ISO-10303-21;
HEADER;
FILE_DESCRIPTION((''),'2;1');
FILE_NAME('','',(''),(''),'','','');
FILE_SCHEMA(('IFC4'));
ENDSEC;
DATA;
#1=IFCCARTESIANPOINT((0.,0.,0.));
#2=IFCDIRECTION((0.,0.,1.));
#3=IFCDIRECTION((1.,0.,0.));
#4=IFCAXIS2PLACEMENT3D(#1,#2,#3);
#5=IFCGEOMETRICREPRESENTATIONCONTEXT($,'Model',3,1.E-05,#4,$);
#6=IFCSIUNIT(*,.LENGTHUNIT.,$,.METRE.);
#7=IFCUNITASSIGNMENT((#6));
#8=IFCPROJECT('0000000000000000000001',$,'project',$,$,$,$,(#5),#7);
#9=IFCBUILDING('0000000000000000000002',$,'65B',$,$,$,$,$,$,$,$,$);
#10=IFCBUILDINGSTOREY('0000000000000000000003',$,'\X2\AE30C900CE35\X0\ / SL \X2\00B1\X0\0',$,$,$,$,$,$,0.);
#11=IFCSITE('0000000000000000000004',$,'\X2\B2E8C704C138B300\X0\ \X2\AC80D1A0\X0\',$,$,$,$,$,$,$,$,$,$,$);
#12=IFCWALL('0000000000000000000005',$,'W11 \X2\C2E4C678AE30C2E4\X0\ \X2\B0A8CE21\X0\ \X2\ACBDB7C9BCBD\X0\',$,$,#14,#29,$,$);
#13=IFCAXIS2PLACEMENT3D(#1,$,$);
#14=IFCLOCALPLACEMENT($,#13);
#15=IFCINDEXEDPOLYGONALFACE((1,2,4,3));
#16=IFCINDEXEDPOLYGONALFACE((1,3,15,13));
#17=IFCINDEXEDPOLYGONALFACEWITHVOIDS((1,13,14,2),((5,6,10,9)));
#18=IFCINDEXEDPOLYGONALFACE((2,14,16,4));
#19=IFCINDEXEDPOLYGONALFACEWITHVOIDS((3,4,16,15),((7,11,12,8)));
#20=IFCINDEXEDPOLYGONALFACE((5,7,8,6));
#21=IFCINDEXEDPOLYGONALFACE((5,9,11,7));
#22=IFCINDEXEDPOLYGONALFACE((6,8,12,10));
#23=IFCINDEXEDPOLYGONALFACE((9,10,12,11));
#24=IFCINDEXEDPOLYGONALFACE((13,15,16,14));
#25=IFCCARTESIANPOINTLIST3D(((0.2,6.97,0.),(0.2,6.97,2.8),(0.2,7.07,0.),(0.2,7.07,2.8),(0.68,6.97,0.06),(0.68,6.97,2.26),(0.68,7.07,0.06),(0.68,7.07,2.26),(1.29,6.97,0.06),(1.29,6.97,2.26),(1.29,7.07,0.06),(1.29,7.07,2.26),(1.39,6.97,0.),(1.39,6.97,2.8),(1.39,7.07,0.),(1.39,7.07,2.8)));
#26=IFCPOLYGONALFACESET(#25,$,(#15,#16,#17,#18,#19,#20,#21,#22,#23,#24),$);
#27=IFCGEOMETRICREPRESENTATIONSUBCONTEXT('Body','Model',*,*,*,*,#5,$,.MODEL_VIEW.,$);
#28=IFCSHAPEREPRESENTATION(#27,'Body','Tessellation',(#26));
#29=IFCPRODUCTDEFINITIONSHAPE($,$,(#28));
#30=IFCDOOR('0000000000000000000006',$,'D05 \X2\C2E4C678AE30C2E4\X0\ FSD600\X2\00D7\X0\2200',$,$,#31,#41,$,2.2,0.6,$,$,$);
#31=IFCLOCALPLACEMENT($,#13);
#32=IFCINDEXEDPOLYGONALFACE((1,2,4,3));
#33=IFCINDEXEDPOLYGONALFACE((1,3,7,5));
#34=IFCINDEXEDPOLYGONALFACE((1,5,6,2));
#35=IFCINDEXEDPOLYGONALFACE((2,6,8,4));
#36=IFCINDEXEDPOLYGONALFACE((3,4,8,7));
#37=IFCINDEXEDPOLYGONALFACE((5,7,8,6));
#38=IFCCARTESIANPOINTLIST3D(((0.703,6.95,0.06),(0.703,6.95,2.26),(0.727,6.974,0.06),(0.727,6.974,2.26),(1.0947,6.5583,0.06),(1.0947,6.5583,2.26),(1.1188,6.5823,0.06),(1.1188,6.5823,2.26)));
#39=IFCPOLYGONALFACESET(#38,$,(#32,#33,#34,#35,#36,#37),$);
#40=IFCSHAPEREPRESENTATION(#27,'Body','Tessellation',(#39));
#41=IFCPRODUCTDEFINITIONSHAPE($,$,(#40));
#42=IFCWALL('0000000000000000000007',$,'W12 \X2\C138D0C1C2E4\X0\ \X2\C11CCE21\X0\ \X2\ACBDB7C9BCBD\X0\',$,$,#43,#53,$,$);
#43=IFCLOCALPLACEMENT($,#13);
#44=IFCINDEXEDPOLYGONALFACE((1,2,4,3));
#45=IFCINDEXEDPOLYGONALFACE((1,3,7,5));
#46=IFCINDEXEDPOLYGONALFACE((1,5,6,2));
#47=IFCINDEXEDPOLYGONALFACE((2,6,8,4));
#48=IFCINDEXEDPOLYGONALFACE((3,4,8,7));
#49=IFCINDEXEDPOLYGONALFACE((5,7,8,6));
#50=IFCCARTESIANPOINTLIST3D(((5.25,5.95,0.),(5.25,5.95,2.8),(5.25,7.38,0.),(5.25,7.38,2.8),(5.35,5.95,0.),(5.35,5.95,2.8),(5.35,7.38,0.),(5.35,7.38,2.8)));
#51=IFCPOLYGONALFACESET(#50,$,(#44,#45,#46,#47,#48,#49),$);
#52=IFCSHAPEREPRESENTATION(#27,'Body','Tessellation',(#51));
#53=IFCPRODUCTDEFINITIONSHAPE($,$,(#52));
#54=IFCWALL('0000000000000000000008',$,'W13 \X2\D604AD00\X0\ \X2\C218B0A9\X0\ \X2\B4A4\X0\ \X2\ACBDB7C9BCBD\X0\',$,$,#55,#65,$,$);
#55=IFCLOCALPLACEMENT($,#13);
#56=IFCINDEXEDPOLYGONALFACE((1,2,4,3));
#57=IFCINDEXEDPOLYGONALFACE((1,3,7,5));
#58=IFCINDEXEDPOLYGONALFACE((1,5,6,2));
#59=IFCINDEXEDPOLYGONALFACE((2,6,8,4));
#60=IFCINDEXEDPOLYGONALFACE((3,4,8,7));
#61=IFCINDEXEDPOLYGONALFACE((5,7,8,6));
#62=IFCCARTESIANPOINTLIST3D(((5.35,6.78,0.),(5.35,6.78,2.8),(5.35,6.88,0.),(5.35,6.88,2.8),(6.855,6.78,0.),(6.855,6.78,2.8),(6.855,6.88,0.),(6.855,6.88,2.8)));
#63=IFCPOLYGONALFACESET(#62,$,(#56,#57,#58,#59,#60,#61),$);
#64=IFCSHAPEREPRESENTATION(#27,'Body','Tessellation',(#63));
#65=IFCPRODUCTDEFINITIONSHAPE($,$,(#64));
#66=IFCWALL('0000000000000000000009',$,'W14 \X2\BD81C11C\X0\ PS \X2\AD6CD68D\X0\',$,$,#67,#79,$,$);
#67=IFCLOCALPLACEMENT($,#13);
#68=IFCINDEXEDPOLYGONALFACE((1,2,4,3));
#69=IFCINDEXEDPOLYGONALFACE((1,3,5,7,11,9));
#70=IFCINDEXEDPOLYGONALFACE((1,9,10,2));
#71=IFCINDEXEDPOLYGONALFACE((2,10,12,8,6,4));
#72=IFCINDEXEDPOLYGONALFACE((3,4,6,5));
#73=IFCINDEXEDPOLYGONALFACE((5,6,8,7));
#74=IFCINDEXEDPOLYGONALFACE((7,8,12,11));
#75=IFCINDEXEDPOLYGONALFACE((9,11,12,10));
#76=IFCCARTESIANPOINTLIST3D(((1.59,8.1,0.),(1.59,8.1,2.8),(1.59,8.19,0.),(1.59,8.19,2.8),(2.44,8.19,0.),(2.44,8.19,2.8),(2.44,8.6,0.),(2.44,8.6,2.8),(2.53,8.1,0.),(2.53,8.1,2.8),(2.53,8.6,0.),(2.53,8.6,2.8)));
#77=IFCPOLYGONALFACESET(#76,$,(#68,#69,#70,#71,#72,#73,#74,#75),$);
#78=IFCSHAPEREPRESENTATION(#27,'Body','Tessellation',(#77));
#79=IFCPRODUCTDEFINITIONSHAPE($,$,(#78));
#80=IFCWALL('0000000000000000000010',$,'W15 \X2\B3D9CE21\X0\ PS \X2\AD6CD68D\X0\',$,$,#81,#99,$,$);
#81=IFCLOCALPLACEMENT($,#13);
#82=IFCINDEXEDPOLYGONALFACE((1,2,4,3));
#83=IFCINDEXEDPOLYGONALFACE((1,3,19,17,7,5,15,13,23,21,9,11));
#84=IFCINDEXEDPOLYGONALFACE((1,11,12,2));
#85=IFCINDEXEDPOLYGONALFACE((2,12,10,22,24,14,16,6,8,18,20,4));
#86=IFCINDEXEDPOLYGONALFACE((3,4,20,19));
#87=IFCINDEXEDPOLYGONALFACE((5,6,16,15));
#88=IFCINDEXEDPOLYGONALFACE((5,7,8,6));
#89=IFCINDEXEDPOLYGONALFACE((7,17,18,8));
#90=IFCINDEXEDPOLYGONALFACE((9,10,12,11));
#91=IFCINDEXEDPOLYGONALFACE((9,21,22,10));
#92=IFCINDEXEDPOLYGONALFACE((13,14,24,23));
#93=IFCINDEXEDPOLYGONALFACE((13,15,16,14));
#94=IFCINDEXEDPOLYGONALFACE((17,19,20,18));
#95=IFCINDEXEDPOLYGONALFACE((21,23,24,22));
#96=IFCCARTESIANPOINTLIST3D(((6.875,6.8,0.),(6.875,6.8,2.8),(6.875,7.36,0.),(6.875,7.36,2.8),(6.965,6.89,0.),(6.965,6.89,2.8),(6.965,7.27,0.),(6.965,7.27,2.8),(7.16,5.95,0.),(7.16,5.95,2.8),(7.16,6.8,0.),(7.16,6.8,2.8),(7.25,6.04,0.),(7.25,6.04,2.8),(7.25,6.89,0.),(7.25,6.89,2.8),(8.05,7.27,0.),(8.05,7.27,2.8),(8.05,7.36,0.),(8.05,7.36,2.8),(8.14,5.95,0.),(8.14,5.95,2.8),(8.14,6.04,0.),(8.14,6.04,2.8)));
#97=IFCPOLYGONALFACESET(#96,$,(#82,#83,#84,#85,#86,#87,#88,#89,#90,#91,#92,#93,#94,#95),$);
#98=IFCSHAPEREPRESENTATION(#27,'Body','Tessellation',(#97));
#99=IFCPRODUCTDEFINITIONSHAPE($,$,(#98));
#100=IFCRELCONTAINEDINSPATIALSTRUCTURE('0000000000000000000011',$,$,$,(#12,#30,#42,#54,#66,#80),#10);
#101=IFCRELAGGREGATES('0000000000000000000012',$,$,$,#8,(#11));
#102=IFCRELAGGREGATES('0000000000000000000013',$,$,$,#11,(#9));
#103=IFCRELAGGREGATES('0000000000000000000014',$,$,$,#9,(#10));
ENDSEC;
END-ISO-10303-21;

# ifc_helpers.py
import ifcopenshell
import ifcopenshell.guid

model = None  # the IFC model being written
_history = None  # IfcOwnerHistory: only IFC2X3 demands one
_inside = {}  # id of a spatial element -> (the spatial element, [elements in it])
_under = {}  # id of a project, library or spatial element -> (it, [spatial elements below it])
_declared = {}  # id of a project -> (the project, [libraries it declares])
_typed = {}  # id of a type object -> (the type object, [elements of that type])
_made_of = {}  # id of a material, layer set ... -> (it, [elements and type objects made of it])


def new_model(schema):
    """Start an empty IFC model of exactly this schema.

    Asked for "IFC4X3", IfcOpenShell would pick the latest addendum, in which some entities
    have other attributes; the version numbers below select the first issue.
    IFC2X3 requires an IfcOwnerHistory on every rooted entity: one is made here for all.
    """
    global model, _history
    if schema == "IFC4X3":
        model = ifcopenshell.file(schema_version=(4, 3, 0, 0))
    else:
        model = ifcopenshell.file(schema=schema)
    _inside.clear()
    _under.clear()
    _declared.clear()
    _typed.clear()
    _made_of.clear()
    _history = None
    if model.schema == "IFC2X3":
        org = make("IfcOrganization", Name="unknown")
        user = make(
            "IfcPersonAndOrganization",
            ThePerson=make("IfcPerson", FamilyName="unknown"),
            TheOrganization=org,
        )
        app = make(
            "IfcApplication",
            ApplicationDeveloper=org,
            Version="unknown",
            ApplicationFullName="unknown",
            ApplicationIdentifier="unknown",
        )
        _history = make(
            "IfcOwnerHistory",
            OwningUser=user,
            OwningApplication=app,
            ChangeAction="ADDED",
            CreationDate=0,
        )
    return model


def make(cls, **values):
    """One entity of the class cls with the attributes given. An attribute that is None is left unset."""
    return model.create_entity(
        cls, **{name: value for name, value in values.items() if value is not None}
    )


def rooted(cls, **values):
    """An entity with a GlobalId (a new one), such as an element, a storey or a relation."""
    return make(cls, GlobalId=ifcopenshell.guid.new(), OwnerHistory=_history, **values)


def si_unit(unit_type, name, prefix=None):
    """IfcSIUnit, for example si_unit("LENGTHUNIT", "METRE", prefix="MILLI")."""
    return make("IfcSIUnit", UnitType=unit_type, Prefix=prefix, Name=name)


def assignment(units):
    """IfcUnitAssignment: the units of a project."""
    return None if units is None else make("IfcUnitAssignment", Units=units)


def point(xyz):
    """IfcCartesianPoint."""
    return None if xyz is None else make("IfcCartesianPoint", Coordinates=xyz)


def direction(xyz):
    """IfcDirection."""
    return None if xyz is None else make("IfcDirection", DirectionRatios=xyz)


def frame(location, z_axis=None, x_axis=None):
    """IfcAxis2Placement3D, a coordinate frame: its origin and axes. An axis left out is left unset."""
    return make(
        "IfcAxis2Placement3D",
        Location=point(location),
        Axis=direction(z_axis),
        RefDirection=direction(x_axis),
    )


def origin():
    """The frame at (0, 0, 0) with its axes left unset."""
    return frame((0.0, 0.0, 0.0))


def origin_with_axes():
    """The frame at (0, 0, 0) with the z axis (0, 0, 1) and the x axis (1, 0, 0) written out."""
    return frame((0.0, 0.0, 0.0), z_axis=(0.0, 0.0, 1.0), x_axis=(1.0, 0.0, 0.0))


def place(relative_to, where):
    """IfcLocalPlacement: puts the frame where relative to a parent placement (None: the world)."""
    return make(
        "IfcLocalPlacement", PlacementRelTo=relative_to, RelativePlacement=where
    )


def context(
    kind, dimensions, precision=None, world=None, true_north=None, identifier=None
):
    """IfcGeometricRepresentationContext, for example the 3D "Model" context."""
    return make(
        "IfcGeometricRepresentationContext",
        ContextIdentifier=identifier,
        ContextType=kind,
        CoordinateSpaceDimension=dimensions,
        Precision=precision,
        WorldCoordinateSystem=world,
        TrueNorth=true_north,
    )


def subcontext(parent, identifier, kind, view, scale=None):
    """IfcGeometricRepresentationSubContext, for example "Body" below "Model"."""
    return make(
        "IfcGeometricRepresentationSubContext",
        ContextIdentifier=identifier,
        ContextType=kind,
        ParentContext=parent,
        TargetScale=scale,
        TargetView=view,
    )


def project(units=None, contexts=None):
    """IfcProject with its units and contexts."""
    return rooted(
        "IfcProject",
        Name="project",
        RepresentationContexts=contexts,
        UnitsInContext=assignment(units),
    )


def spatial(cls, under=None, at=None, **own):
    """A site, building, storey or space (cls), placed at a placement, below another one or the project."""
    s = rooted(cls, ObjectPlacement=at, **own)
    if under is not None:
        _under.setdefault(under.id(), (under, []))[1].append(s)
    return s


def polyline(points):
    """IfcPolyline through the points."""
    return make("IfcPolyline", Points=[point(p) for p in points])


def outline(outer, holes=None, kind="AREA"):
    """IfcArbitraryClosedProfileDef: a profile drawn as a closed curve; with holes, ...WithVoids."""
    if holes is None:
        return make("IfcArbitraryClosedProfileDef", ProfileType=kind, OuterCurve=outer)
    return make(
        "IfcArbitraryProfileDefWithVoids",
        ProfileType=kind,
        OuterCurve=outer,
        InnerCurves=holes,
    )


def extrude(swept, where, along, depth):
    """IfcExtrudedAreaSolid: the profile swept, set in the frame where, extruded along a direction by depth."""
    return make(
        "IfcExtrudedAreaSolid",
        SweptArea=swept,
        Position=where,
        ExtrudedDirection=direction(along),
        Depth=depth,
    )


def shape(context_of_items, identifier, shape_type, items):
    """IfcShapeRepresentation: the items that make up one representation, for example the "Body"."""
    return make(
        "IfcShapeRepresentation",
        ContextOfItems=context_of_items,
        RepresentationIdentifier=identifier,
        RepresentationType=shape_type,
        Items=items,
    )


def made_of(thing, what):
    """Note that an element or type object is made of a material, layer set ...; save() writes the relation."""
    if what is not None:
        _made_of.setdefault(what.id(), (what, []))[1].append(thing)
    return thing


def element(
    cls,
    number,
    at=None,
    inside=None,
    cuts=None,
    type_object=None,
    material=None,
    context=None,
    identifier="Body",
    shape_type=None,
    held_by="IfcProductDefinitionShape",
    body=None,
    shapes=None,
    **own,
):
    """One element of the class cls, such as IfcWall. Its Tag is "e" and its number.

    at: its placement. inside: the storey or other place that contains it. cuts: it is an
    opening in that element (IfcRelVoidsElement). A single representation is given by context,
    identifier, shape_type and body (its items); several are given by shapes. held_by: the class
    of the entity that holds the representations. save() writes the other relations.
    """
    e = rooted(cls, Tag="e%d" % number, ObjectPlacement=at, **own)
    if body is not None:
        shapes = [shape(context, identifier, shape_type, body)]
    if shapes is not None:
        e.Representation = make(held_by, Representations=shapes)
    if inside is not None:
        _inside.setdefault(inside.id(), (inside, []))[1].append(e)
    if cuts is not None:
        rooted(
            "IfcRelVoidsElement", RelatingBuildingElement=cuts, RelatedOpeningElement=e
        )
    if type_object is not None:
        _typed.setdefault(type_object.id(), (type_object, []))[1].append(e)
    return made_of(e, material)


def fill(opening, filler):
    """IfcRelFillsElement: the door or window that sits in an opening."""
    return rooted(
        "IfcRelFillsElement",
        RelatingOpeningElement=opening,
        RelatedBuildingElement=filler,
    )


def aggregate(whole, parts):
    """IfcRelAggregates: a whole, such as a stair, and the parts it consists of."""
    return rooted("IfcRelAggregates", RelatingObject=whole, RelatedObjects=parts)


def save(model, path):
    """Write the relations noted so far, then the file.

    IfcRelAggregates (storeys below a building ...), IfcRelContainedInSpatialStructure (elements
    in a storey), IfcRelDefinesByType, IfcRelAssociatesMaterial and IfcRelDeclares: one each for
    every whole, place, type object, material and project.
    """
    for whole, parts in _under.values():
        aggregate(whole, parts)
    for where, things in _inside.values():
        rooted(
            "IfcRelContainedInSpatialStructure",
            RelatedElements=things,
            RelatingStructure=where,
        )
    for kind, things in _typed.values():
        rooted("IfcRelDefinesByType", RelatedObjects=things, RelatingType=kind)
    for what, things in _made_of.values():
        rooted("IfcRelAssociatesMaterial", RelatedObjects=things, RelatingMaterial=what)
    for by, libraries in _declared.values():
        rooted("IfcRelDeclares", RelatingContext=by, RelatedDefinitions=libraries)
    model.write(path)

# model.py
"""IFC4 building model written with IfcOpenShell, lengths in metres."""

from ifc_helpers import new_model, si_unit, frame, origin, origin_with_axes, place, context, subcontext, project, spatial, polyline, outline, extrude, element, fill, save


model = new_model("IFC4")

# Units and contexts
model_context = context("Model", 3, precision=1e-05, world=origin_with_axes())
body_context = subcontext(model_context, "Body", "Model", "MODEL_VIEW")
ifc_project = project(units=[si_unit("LENGTHUNIT", "METRE")], contexts=[model_context])

# Site, building, storey
site = spatial("IfcSite", under=ifc_project, Name="단위세대 검토")
building = spatial("IfcBuilding", under=site, Name="65B")
storey = spatial("IfcBuildingStorey", under=building, Name="기준층 / SL ±0", Elevation=0.0)

# Wall, opening, door
wall_1_placement = place(None, origin_with_axes())
wall_1 = element("IfcWall", 1, at=wall_1_placement, inside=storey, Name="W11 실외기실 남측 경량벽", context=body_context, shape_type="SweptSolid", body=[
    extrude(outline(polyline([(1.39, 6.97), (1.39, 7.07), (0.2, 7.07), (0.2, 6.97), (1.39, 6.97)])), origin(), (0.0, 0.0, 1.0), 2.8),
])
opening_1_placement = place(wall_1_placement, origin_with_axes())
opening_1 = element("IfcOpeningElement", 2, at=opening_1_placement, cuts=wall_1, context=body_context, shape_type="SweptSolid", body=[
    extrude(outline(polyline([(1.29, 6.969), (1.29, 7.071), (0.68, 7.071), (0.68, 6.969), (1.29, 6.969)])), frame((0.0, 0.0, 0.06)), (0.0, 0.0, 1.0), 2.2),
])
door_placement = place(None, origin_with_axes())
door = element("IfcDoor", 3, at=door_placement, inside=storey, Name="D05 실외기실 FSD600×2200", OverallHeight=2.2, OverallWidth=0.6, context=body_context, shape_type="SweptSolid", body=[
    extrude(outline(polyline([(0.727, 6.974), (0.703, 6.95), (1.0947, 6.5583), (1.1188, 6.5823), (0.727, 6.974)])), frame((0.0, 0.0, 0.06)), (0.0, 0.0, 1.0), 2.2),
])
fill(opening_1, door)

# Walls
wall_2_placement = place(None, origin_with_axes())
element("IfcWall", 4, at=wall_2_placement, inside=storey, Name="W12 세탁실 서측 경량벽", context=body_context, shape_type="SweptSolid", body=[
    extrude(outline(polyline([(5.35, 5.95), (5.35, 7.38), (5.25, 7.38), (5.25, 5.95), (5.35, 5.95)])), origin(), (0.0, 0.0, 1.0), 2.8),
])
wall_3_placement = place(None, origin_with_axes())
element("IfcWall", 5, at=wall_3_placement, inside=storey, Name="W13 현관 수납 뒤 경량벽", context=body_context, shape_type="SweptSolid", body=[
    extrude(outline(polyline([(6.855, 6.78), (6.855, 6.88), (5.35, 6.88), (5.35, 6.78), (6.855, 6.78)])), origin(), (0.0, 0.0, 1.0), 2.8),
])
wall_4_placement = place(None, origin_with_axes())
element("IfcWall", 6, at=wall_4_placement, inside=storey, Name="W14 북서 PS 구획", context=body_context, shape_type="SweptSolid", body=[
    extrude(outline(polyline([(1.59, 8.1), (2.53, 8.1), (2.53, 8.6), (2.44, 8.6), (2.44, 8.19), (1.59, 8.19), (1.59, 8.1)])), origin(), (0.0, 0.0, 1.0), 2.8),
])
wall_5_placement = place(None, origin_with_axes())
element("IfcWall", 7, at=wall_5_placement, inside=storey, Name="W15 동측 PS 구획", context=body_context, shape_type="SweptSolid", body=[
    extrude(outline(polyline([(6.875, 7.36), (6.875, 6.8), (7.16, 6.8), (7.16, 5.95), (8.14, 5.95), (8.14, 6.04), (7.25, 6.04), (7.25, 6.89), (6.965, 6.89), (6.965, 7.27), (8.05, 7.27), (8.05, 7.36), (6.875, 7.36)])), origin(), (0.0, 0.0, 1.0), 2.8),
])

save(model, "model.ifc")
